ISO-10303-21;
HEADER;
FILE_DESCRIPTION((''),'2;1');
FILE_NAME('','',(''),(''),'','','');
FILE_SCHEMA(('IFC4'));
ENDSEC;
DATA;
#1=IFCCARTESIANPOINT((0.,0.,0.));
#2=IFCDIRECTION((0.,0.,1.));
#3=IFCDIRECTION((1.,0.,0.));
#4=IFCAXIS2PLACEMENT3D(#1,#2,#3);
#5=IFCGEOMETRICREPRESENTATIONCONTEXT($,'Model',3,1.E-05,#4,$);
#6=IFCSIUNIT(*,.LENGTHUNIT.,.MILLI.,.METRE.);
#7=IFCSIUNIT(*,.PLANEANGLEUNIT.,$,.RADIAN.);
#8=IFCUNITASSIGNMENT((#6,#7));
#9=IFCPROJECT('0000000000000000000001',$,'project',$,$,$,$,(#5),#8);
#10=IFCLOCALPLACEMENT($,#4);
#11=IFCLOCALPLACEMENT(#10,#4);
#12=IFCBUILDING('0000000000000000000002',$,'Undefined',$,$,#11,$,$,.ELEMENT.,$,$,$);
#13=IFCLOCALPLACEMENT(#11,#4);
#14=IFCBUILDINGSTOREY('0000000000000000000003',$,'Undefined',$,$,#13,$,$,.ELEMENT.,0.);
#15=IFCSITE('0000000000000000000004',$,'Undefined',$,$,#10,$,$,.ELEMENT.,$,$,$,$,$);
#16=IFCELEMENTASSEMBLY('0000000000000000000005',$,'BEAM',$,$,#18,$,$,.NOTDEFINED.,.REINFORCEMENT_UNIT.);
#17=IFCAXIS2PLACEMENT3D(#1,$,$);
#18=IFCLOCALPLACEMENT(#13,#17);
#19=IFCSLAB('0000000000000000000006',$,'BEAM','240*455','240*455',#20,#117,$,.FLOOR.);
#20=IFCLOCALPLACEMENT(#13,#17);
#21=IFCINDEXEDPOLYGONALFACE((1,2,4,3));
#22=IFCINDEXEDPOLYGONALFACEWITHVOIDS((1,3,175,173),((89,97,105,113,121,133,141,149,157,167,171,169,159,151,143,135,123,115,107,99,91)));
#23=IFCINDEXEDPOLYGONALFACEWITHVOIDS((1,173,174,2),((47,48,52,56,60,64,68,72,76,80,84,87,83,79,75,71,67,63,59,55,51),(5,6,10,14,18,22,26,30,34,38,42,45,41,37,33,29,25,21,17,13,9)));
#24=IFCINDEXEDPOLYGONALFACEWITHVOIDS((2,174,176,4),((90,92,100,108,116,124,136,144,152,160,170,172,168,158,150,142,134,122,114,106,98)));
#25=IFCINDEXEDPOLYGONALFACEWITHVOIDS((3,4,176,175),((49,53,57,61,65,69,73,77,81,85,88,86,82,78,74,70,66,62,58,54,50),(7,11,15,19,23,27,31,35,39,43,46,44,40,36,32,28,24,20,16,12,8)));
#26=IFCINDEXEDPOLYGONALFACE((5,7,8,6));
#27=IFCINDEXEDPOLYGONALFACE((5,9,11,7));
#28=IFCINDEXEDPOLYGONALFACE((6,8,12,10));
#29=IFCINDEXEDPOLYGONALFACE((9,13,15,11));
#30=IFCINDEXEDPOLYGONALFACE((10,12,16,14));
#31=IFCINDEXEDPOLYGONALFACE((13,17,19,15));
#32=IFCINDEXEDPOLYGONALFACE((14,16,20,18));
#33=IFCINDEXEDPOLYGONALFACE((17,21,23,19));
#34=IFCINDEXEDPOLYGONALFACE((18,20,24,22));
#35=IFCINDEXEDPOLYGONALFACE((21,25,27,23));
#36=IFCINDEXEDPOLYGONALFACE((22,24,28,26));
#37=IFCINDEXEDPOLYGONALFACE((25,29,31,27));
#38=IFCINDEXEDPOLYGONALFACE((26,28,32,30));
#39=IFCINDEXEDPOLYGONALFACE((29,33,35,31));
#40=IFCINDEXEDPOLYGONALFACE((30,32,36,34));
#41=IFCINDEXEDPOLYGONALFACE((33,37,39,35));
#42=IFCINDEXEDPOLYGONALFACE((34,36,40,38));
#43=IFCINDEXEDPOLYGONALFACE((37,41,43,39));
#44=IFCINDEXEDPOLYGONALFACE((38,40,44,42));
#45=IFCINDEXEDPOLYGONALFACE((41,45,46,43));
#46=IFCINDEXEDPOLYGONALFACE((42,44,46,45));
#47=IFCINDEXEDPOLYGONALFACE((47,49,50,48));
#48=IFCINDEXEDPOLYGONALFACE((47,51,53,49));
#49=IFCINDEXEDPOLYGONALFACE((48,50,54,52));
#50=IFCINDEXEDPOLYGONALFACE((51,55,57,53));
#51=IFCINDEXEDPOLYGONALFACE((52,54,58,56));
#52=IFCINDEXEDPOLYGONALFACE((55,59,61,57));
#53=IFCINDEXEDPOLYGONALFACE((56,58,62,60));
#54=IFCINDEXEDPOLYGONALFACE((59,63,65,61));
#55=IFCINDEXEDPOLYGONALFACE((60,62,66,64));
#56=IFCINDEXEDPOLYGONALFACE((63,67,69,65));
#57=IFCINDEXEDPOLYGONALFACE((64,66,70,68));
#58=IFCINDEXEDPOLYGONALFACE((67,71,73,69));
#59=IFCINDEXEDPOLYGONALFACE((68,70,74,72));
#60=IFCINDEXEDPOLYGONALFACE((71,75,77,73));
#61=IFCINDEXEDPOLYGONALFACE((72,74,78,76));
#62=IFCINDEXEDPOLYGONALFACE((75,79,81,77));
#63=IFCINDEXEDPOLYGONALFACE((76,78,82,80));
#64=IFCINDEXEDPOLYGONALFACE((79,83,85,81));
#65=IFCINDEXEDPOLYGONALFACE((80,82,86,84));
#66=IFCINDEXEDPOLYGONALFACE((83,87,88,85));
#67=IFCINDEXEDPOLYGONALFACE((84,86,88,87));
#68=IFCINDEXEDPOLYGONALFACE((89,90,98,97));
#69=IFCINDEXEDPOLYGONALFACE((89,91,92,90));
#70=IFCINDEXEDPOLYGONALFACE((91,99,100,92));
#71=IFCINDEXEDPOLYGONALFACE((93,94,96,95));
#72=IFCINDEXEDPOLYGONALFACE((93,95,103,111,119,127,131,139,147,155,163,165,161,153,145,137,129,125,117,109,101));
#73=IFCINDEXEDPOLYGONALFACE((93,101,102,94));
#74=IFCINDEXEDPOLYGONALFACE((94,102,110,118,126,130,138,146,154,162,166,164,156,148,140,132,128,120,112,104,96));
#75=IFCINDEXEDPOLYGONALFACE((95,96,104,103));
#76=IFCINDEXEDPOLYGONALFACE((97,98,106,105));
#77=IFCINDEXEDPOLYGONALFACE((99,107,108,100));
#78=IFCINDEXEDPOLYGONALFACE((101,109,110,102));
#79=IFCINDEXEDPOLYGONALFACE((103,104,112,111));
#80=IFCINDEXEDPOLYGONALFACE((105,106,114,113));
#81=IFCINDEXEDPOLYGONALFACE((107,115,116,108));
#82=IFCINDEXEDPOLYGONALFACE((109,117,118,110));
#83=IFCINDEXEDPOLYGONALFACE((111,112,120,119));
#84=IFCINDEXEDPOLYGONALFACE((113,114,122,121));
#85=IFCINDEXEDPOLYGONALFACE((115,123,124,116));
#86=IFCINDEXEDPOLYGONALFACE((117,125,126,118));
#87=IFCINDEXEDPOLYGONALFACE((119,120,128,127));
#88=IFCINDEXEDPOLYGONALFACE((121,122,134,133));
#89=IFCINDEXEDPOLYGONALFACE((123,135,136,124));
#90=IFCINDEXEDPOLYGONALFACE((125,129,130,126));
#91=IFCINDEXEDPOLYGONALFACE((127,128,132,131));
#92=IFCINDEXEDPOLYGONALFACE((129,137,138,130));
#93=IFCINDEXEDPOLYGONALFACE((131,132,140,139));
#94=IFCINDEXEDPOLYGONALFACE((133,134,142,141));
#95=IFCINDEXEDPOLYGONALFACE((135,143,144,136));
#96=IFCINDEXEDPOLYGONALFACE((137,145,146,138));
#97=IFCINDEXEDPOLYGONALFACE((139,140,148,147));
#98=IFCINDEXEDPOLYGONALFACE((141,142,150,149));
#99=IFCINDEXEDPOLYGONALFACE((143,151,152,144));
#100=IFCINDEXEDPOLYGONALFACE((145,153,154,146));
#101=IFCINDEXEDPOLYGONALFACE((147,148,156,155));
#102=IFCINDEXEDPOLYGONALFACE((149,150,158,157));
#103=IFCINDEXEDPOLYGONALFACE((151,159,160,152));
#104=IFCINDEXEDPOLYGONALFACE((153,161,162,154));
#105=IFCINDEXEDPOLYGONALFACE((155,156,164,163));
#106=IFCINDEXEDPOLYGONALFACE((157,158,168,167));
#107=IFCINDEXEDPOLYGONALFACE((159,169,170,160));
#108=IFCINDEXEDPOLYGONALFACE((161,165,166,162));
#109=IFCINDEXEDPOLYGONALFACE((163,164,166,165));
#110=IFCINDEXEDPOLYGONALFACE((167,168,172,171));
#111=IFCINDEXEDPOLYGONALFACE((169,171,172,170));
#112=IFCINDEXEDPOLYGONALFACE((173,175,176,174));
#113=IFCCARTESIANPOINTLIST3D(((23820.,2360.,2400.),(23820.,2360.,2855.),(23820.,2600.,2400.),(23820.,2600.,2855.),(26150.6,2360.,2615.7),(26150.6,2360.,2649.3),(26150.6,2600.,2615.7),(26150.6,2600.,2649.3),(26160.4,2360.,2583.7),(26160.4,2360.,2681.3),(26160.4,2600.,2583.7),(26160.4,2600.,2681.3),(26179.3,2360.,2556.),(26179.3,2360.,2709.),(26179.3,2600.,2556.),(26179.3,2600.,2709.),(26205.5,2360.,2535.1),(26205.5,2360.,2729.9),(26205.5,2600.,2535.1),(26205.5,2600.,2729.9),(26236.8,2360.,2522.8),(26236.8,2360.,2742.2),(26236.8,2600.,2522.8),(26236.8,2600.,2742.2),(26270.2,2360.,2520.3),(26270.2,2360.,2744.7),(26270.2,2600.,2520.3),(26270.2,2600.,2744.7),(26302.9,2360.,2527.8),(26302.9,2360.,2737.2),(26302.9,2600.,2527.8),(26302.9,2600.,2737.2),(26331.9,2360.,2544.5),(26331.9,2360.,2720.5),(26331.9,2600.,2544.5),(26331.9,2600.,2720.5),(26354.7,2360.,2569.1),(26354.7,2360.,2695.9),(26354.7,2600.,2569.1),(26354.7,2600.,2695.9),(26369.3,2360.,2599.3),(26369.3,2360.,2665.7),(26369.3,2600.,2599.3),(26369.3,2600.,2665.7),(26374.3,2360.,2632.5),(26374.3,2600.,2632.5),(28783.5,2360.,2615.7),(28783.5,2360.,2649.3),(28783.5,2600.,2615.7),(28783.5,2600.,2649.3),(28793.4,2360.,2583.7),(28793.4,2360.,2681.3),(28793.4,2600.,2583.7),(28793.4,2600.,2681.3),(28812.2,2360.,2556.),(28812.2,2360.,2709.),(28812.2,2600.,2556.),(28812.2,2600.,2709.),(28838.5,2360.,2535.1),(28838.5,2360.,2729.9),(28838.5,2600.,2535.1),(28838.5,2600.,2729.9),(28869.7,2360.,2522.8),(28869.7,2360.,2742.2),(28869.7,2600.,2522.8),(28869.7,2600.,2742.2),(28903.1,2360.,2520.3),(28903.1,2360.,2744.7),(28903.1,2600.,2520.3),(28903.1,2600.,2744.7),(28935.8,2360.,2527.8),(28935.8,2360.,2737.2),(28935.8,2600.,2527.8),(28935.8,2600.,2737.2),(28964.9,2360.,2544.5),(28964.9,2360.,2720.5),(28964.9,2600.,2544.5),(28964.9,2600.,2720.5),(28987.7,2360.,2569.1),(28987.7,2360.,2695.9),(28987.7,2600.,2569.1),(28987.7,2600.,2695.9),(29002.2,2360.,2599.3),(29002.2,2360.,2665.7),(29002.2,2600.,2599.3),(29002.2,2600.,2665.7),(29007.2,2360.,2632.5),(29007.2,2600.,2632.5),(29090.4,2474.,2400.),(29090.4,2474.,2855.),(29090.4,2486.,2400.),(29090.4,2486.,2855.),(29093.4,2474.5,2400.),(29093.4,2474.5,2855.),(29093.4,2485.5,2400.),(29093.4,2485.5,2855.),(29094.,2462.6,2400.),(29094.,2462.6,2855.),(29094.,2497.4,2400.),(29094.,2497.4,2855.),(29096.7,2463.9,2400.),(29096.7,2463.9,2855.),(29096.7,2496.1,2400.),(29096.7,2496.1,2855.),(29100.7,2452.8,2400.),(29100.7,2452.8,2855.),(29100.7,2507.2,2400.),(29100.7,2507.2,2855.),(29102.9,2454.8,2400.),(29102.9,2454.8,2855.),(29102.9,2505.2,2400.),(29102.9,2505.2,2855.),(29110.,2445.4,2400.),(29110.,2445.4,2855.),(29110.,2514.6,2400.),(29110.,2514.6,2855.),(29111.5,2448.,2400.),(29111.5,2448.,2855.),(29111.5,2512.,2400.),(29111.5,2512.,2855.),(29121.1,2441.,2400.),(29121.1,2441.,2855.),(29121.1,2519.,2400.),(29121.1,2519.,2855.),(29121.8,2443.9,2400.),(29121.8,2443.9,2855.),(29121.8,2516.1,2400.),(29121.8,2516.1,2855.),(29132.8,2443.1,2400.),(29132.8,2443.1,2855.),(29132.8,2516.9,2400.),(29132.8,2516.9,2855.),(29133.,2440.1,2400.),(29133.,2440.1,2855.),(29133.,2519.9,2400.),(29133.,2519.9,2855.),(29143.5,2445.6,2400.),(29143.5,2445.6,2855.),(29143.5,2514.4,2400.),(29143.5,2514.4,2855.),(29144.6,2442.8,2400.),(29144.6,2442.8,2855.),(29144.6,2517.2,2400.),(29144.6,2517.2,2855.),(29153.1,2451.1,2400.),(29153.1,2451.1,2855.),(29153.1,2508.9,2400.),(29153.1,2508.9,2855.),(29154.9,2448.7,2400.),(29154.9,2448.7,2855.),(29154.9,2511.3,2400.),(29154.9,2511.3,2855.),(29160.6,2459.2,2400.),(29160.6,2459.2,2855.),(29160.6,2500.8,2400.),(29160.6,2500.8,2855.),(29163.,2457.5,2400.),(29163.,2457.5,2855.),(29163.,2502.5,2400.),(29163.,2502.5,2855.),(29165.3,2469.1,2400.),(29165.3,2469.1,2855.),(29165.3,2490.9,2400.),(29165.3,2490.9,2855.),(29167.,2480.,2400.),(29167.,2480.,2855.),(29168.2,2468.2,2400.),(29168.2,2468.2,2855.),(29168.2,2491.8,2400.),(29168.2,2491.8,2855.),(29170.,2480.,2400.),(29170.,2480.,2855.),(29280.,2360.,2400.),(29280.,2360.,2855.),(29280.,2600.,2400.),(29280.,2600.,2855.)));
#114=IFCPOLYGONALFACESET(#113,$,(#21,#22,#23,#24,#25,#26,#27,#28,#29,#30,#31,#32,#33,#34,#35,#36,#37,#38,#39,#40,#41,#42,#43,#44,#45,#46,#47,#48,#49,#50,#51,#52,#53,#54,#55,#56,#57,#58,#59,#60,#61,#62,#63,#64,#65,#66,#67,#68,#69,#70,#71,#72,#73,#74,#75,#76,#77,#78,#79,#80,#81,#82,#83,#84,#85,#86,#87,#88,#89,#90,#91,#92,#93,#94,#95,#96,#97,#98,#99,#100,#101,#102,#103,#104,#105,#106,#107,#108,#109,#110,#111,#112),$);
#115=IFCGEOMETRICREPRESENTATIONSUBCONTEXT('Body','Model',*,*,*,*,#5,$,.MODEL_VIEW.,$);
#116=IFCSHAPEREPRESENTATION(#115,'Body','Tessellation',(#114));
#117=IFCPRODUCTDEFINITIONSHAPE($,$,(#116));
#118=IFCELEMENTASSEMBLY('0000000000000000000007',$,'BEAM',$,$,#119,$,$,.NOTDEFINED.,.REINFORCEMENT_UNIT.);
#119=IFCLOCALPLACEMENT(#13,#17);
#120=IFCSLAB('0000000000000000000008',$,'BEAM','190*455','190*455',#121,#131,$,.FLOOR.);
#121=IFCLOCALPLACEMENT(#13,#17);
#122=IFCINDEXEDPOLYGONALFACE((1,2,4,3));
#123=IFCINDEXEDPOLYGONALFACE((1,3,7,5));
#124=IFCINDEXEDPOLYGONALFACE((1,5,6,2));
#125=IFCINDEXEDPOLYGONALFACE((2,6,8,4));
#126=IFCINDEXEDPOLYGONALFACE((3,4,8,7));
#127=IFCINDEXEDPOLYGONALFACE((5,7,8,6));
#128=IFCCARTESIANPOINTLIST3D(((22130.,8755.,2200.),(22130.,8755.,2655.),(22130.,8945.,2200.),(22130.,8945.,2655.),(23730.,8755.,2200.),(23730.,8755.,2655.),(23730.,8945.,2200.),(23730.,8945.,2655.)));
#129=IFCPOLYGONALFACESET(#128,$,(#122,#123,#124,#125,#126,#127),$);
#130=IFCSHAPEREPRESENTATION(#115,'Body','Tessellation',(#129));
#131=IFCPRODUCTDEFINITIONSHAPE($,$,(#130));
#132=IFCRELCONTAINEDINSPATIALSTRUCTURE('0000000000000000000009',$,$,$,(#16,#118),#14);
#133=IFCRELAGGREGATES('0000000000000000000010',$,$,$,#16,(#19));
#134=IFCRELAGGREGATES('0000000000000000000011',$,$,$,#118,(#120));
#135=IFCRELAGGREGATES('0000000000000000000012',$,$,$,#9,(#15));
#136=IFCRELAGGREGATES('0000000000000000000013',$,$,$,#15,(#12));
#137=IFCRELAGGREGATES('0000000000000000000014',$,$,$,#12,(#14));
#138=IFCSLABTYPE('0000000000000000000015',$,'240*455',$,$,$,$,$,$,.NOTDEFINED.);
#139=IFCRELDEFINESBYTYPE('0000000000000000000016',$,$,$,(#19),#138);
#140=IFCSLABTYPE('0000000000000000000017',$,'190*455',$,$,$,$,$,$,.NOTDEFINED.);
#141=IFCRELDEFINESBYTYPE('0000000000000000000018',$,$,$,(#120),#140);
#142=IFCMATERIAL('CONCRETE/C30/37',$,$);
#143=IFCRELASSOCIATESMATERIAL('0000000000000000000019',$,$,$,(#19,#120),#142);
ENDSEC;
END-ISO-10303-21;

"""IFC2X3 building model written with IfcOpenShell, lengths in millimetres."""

from ifc_helpers import new_model, si_unit, frame, origin_with_axes, origin_2d_with_axis, place, context, subcontext, project, spatial, polyline, circle, hollow_circle, outline, extrude, boolean, material, type_object, element, aggregate, save


model = new_model("IFC2X3")

# Units and contexts
model_context = context("Model", 3, precision=1e-05, world=origin_with_axes())
body_context = subcontext(model_context, "Body", "Model", "MODEL_VIEW")
ifc_project = project(units=[si_unit("LENGTHUNIT", "METRE", prefix="MILLI"), si_unit("PLANEANGLEUNIT", "RADIAN")], contexts=[model_context])

# Site, building, storey
site_placement = place(None, origin_with_axes())
site = spatial("IfcSite", under=ifc_project, at=site_placement, Name="Undefined", CompositionType="ELEMENT")
building_placement = place(site_placement, origin_with_axes())
building = spatial("IfcBuilding", under=site, at=building_placement, Name="Undefined", CompositionType="ELEMENT")
storey_placement = place(building_placement, origin_with_axes())
storey = spatial("IfcBuildingStorey", under=building, at=storey_placement, Name="Undefined", CompositionType="ELEMENT", Elevation=0.0)

# Element assembly, slab
assembly_1_placement = place(storey_placement, origin_with_axes())
assembly_1 = element("IfcElementAssembly", 1, at=assembly_1_placement, inside=storey, Name="BEAM", AssemblyPlace="NOTDEFINED", PredefinedType="REINFORCEMENT_UNIT")
ifc_material_1 = material(Name="CONCRETE/C30/37")
slab_type_1 = type_object("IfcSlabType", Name="240*455", PredefinedType="NOTDEFINED")
slab_1_placement = place(assembly_1_placement, frame((23820.0, 2480.0, 2400.0), z_axis=(0.0, 1.0, 0.0), x_axis=(0.0, 0.0, 1.0)))
slab_1 = element("IfcSlab", 2, at=slab_1_placement, type_object=slab_type_1, material=ifc_material_1, Name="BEAM", Description="240*455", ObjectType="240*455", PredefinedType="FLOOR", context=body_context, shape_type="CSG", body=[
    boolean("DIFFERENCE", boolean("DIFFERENCE", boolean("DIFFERENCE", extrude(outline(polyline([(0.0, 0.0), (455.0, 0.0), (455.0, 5460.0), (0.0, 5460.0), (0.0, 0.0)])), frame((0.0, 0.0, -120.0), z_axis=(0.0, 0.0, 1.0), x_axis=(1.0, 0.0, 0.0)), (0.0, 0.0, 1.0), 240.0), extrude(hollow_circle(Radius=40.0, WallThickness=3.0, at=origin_2d_with_axis()), frame((455.0, 5310.0, 0.0), z_axis=(-1.0, 0.0, 0.0), x_axis=(0.0, 1.0, 0.0)), (0.0, 0.0, 1.0), 455.0)), extrude(circle(Radius=112.5, at=origin_2d_with_axis()), frame((232.5, 2441.8, 125.4), z_axis=(0.0, 0.0, -1.0), x_axis=(0.0, 1.0, 0.0)), (0.0, 0.0, 1.0), 250.0)), extrude(circle(Radius=112.5, at=origin_2d_with_axis()), frame((232.5, 5074.7, 125.4), z_axis=(0.0, 0.0, -1.0), x_axis=(0.0, 1.0, 0.0)), (0.0, 0.0, 1.0), 250.0)),
])

# Element assembly, slab
assembly_2_placement = place(storey_placement, origin_with_axes())
assembly_2 = element("IfcElementAssembly", 3, at=assembly_2_placement, inside=storey, Name="BEAM", AssemblyPlace="NOTDEFINED", PredefinedType="REINFORCEMENT_UNIT")
slab_type_2 = type_object("IfcSlabType", Name="190*455", PredefinedType="NOTDEFINED")
slab_2_placement = place(assembly_2_placement, frame((22130.0, 8850.0, 2200.0), z_axis=(0.0, 1.0, 0.0), x_axis=(0.0, 0.0, 1.0)))
slab_2 = element("IfcSlab", 4, at=slab_2_placement, type_object=slab_type_2, material=ifc_material_1, Name="BEAM", Description="190*455", ObjectType="190*455", PredefinedType="FLOOR", context=body_context, shape_type="SweptSolid", body=[
    extrude(outline(polyline([(0.0, 0.0), (455.0, 0.0), (455.0, 1600.0), (0.0, 1600.0), (0.0, 0.0)])), frame((0.0, 0.0, -95.0), z_axis=(0.0, 0.0, 1.0), x_axis=(1.0, 0.0, 0.0)), (0.0, 0.0, 1.0), 190.0),
])

aggregate(assembly_1, [slab_1])
aggregate(assembly_2, [slab_2])

save(model, "model.ifc")
